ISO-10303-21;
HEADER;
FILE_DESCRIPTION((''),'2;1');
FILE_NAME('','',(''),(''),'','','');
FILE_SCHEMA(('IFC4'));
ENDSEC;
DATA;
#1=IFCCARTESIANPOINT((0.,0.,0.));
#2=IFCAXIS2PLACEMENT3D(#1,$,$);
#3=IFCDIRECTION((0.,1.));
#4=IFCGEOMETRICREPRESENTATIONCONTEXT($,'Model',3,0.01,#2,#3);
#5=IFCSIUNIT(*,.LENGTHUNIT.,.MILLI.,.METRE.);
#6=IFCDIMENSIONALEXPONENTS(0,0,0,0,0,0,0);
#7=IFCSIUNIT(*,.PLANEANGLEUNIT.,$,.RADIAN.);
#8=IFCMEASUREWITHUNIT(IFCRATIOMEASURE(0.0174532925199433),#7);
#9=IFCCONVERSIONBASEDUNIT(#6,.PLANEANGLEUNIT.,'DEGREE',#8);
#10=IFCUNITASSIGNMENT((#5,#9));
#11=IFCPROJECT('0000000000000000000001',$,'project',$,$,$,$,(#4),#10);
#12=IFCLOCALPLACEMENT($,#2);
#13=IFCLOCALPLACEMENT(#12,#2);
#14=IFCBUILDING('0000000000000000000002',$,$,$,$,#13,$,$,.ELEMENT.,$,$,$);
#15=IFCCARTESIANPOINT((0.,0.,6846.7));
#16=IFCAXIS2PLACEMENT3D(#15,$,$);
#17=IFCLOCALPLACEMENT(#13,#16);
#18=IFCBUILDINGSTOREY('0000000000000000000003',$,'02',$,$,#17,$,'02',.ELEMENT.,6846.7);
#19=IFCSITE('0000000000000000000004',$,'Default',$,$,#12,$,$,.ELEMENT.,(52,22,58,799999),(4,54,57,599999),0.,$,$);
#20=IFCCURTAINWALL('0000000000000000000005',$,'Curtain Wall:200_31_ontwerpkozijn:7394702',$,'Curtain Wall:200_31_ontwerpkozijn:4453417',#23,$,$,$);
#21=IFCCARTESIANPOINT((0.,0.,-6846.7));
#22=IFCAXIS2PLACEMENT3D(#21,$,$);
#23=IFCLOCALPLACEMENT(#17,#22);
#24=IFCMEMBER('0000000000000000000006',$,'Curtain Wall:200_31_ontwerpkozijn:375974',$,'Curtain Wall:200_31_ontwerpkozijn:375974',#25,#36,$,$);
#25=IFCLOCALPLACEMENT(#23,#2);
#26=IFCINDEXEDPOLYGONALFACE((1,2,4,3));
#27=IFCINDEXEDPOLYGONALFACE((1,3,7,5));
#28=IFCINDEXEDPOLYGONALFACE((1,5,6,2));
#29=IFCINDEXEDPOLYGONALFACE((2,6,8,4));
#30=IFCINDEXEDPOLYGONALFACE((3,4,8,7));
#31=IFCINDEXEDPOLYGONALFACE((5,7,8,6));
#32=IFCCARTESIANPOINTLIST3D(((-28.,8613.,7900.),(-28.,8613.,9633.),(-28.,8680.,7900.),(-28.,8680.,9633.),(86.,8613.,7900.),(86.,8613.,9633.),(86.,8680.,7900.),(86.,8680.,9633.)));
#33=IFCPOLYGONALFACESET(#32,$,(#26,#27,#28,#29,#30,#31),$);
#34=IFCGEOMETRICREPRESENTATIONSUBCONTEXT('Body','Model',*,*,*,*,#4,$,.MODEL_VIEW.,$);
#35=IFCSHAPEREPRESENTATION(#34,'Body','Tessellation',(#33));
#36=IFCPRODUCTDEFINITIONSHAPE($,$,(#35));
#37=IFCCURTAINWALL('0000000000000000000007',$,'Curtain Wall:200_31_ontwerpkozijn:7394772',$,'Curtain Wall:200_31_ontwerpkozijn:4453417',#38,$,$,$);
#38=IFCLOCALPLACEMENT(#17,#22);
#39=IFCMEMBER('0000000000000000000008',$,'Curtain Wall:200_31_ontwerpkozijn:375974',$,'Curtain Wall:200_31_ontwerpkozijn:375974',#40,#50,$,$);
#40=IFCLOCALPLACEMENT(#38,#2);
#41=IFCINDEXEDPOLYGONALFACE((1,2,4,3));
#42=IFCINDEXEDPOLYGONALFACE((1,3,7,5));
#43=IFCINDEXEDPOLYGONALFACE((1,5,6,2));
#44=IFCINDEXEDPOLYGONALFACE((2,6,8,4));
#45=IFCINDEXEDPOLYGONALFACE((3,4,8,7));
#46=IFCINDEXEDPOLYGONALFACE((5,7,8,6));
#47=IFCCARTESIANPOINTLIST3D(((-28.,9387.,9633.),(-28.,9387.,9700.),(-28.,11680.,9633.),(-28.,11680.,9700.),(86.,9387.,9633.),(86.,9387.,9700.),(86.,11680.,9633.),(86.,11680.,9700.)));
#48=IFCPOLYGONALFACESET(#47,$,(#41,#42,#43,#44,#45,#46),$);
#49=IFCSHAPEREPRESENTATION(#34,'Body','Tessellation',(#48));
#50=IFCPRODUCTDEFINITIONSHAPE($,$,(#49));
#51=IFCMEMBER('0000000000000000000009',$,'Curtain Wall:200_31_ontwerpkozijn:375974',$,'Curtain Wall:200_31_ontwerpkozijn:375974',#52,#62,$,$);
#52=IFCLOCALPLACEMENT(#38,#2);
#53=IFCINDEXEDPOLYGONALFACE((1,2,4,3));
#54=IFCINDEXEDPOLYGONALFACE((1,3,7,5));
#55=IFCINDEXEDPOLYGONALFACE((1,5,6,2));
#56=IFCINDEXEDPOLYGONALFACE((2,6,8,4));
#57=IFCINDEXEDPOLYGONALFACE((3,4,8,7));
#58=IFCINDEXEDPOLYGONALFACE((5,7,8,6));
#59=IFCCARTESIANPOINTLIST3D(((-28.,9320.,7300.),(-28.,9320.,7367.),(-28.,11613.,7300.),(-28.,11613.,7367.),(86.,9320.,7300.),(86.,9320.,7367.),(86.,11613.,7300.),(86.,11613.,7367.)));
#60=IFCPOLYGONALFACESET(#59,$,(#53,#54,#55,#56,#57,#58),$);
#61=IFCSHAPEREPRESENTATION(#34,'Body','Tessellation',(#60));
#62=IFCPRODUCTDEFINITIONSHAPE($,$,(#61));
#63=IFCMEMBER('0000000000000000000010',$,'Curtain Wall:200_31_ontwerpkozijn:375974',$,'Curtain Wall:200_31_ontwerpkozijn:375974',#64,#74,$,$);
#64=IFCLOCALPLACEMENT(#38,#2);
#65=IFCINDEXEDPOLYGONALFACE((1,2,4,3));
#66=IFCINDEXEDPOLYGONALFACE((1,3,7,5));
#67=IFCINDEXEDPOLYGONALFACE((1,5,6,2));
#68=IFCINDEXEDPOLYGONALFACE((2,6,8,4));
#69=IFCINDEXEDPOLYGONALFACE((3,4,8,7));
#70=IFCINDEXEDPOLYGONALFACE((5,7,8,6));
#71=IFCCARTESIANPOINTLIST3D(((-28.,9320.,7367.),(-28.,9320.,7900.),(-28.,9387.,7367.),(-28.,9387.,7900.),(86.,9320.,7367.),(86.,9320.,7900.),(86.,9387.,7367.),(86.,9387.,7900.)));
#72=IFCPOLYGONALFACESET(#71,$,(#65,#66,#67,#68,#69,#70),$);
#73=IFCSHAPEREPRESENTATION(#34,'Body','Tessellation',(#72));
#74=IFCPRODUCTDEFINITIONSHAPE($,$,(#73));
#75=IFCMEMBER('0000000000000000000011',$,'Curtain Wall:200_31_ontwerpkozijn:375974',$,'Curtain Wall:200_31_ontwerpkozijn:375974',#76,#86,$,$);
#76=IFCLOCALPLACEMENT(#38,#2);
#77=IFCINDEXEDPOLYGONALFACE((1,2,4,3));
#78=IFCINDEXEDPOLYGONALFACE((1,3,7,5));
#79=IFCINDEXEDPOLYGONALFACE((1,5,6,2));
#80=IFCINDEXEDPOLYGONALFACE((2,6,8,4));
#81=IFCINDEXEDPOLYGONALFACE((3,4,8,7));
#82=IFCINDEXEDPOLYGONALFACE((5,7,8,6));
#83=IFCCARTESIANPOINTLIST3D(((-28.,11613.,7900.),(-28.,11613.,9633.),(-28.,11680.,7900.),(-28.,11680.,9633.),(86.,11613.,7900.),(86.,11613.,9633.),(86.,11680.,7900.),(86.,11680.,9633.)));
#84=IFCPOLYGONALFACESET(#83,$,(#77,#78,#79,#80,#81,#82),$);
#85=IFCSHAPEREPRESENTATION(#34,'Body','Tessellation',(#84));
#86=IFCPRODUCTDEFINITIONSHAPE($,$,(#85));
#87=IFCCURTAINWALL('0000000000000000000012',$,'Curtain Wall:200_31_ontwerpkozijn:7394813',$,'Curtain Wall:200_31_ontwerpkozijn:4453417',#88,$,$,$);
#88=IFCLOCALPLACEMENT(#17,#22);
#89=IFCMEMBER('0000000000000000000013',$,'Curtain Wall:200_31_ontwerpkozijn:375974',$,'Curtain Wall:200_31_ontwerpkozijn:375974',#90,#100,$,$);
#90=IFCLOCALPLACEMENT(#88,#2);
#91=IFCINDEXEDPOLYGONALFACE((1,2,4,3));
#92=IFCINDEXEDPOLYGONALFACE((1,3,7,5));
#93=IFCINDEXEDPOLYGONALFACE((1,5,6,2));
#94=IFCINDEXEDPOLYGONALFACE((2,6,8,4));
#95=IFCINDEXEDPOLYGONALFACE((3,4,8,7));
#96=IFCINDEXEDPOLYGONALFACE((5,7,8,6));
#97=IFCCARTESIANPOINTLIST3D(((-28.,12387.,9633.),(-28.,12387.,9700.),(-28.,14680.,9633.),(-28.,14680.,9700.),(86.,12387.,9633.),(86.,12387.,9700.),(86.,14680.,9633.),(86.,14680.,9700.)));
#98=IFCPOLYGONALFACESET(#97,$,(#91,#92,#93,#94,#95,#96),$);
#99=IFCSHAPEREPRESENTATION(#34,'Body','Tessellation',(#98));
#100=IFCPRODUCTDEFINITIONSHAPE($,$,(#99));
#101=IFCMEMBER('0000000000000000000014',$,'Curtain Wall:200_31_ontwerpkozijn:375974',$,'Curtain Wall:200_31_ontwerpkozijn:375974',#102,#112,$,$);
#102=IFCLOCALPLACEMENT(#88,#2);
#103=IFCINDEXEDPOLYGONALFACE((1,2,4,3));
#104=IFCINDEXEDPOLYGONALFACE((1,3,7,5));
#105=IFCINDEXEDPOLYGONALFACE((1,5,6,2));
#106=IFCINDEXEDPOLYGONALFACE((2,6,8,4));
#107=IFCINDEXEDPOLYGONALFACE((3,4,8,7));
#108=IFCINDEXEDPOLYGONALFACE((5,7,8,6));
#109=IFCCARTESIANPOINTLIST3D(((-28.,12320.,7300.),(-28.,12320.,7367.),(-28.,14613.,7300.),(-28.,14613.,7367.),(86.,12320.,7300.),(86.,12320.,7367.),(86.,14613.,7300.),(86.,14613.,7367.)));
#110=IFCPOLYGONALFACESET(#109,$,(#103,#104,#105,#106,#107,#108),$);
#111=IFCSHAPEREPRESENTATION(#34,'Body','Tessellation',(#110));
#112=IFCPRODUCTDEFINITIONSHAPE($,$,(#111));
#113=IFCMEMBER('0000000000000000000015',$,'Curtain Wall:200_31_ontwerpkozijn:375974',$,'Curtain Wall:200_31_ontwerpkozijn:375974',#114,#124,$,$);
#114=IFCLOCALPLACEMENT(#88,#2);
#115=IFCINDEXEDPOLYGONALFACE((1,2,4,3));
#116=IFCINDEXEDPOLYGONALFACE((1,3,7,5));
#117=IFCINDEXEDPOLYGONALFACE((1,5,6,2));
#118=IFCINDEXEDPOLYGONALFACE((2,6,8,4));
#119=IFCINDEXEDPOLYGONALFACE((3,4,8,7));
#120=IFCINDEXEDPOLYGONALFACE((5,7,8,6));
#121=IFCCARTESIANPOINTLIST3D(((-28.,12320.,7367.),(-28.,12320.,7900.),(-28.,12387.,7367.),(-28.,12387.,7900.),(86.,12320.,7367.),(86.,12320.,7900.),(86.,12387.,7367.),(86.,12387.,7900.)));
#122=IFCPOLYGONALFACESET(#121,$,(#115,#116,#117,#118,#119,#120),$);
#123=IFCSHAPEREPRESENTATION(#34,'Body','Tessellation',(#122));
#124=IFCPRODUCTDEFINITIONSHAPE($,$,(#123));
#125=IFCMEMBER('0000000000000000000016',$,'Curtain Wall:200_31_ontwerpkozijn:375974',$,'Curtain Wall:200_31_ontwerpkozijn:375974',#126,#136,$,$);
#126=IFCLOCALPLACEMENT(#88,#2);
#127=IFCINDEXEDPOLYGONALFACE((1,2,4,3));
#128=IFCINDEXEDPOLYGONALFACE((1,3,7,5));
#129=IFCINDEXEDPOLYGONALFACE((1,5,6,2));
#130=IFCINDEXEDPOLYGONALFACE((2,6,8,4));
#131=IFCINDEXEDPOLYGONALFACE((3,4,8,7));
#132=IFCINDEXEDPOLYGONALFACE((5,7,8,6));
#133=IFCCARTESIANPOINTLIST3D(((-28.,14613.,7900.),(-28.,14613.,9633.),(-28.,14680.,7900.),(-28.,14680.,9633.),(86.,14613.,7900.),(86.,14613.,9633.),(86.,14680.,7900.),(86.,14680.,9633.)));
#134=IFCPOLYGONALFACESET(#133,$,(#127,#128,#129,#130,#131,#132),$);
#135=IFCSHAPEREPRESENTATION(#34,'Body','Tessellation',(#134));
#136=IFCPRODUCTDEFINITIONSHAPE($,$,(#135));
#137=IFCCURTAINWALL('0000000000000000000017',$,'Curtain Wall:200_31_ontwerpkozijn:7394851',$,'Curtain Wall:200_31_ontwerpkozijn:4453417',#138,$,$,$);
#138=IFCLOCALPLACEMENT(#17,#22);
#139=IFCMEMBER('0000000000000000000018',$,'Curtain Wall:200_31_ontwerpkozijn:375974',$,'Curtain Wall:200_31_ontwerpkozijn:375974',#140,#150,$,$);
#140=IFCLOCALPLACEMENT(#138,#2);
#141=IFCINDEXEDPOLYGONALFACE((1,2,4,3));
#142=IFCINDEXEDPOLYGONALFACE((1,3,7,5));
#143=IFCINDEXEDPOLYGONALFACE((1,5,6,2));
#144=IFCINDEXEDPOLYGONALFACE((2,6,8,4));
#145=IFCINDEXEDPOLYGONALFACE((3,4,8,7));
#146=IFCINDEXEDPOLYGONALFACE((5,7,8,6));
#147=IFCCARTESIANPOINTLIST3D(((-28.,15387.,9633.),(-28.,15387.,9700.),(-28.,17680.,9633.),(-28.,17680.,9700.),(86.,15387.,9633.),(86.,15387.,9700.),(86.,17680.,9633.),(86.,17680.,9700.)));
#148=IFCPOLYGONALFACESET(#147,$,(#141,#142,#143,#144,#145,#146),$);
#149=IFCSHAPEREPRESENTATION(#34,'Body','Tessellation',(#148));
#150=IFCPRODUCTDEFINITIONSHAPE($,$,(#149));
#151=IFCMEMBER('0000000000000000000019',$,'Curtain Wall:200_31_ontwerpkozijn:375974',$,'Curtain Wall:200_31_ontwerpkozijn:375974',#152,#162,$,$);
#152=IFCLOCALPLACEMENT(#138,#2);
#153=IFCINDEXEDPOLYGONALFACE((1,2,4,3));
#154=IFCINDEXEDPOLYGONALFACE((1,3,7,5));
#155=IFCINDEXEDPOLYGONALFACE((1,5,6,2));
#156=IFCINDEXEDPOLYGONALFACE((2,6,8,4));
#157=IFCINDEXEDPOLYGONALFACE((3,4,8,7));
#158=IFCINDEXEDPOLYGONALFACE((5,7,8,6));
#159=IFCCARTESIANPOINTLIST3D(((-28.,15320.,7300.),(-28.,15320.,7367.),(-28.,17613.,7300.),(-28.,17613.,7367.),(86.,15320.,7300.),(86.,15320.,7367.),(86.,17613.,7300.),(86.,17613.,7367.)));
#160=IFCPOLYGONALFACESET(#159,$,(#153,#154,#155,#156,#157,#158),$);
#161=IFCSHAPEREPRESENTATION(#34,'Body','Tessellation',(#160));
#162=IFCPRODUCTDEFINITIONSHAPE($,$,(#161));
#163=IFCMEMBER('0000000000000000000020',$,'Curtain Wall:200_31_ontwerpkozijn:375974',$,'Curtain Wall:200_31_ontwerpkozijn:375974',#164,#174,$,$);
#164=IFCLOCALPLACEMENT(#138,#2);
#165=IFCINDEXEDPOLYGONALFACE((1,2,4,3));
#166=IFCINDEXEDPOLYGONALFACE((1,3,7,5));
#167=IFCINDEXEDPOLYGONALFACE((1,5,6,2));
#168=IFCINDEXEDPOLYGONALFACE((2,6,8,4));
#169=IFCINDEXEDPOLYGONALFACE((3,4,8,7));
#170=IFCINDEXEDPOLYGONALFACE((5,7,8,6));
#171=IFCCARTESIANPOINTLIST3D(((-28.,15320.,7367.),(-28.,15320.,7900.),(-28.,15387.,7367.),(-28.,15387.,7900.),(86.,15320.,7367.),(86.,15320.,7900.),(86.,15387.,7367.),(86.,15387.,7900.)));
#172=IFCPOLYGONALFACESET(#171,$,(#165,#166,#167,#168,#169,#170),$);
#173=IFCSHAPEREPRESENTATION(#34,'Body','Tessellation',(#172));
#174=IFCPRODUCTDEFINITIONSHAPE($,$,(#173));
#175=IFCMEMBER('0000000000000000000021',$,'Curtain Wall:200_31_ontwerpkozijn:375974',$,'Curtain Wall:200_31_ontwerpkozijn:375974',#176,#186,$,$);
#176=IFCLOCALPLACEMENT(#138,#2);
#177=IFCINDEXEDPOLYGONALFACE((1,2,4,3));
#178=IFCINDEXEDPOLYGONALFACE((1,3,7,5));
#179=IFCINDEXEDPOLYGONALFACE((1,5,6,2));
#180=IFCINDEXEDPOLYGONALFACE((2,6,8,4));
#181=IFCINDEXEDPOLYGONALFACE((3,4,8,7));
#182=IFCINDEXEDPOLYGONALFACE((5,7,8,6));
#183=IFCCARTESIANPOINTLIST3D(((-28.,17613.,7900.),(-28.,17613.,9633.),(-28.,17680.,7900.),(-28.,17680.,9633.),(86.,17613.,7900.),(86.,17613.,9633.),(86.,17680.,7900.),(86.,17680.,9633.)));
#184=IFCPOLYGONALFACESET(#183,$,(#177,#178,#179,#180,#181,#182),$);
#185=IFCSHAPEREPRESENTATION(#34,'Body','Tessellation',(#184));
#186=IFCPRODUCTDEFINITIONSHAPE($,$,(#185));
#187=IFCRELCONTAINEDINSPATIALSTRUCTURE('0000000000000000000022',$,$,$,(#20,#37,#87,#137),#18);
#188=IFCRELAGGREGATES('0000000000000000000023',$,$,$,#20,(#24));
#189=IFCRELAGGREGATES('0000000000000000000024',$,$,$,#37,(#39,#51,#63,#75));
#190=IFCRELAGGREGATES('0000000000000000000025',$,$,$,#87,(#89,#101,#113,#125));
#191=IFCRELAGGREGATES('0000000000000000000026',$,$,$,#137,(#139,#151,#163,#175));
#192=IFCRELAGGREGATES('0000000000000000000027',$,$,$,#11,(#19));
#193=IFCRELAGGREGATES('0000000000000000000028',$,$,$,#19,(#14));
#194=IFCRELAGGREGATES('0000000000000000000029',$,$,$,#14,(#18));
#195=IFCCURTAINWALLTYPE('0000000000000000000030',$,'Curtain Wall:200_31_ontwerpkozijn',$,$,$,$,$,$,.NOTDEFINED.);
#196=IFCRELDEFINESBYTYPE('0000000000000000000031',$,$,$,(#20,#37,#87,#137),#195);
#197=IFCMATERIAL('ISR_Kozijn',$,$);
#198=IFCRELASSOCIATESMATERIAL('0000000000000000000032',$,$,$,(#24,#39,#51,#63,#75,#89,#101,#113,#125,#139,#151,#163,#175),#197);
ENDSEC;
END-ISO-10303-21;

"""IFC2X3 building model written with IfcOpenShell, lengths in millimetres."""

from ifc_helpers import new_model, entity, si_unit, converted_unit, direction, frame, frame_2d, origin, origin_2d_with_axis, place, context, subcontext, project, spatial, rectangle, extrude, material, type_object, element, aggregate, save


model = new_model("IFC2X3")

# Units and contexts
model_context = context("Model", 3, precision=0.01, world=origin(), true_north=direction((0.0, 1.0)))
body_context = subcontext(model_context, "Body", "Model", "MODEL_VIEW")
ifc_project = project(units=[si_unit("LENGTHUNIT", "METRE", prefix="MILLI"), converted_unit("PLANEANGLEUNIT", "DEGREE", entity("IfcRatioMeasure", 0.0174532925199433), si_unit("PLANEANGLEUNIT", "RADIAN"), dimensions=[0, 0, 0, 0, 0, 0, 0])], contexts=[model_context])

# Site, building, storey
site_placement = place(None, origin())
site = spatial("IfcSite", under=ifc_project, at=site_placement, Name="Default", CompositionType="ELEMENT", RefLatitude=(52, 22, 58, 799999), RefLongitude=(4, 54, 57, 599999), RefElevation=0.0)
building_placement = place(site_placement, origin())
building = spatial("IfcBuilding", under=site, at=building_placement, CompositionType="ELEMENT")
storey_placement = place(building_placement, frame((0.0, 0.0, 6846.7)))
storey = spatial("IfcBuildingStorey", under=building, at=storey_placement, Name="02", LongName="02", CompositionType="ELEMENT", Elevation=6846.7)

# Curtain wall, member
curtain_wall_type = type_object("IfcCurtainWallType", Name="Curtain Wall:200_31_ontwerpkozijn", PredefinedType="NOTDEFINED")
curtain_wall_1_placement = place(storey_placement, frame((0.0, 0.0, -6846.7)))
curtain_wall_1 = element("IfcCurtainWall", 1, at=curtain_wall_1_placement, inside=storey, type_object=curtain_wall_type, Name="Curtain Wall:200_31_ontwerpkozijn:7394702", ObjectType="Curtain Wall:200_31_ontwerpkozijn:4453417")
ifc_material = material(Name="ISR_Kozijn")
member_1_placement = place(curtain_wall_1_placement, origin())
member_1 = element("IfcMember", 2, at=member_1_placement, material=ifc_material, Name="Curtain Wall:200_31_ontwerpkozijn:375974", ObjectType="Curtain Wall:200_31_ontwerpkozijn:375974", context=body_context, shape_type="SweptSolid", body=[
    extrude(rectangle(XDim=114.0, YDim=67.0, at=origin_2d_with_axis()), frame((29.0, 8646.5, 9633.0), z_axis=(0.0, 0.0, -1.0), x_axis=(-1.0, 0.0, 0.0)), (0.0, 0.0, 1.0), 1733.0),
])
aggregate(curtain_wall_1, [member_1])

# Curtain walls, members
curtain_wall_2_placement = place(storey_placement, frame((0.0, 0.0, -6846.7)))
curtain_wall_2 = element("IfcCurtainWall", 3, at=curtain_wall_2_placement, inside=storey, type_object=curtain_wall_type, Name="Curtain Wall:200_31_ontwerpkozijn:7394772", ObjectType="Curtain Wall:200_31_ontwerpkozijn:4453417")
member_2_placement = place(curtain_wall_2_placement, origin())
member_2 = element("IfcMember", 4, at=member_2_placement, material=ifc_material, Name="Curtain Wall:200_31_ontwerpkozijn:375974", ObjectType="Curtain Wall:200_31_ontwerpkozijn:375974", context=body_context, shape_type="SweptSolid", body=[
    extrude(rectangle(XDim=67.0, YDim=114.0, at=origin_2d_with_axis()), frame((29.0, 9387.0, 9666.5), z_axis=(0.0, 1.0, 0.0), x_axis=(0.0, 0.0, -1.0)), (0.0, 0.0, 1.0), 2293.0),
])
member_3_placement = place(curtain_wall_2_placement, origin())
member_3 = element("IfcMember", 5, at=member_3_placement, material=ifc_material, Name="Curtain Wall:200_31_ontwerpkozijn:375974", ObjectType="Curtain Wall:200_31_ontwerpkozijn:375974", context=body_context, shape_type="SweptSolid", body=[
    extrude(rectangle(XDim=67.0, YDim=114.0, at=frame_2d((0.0, 0.0), x_axis=(1.0, 0.0))), frame((29.0, 11613.0, 7333.5), z_axis=(0.0, -1.0, 0.0), x_axis=(0.0, 0.0, -1.0)), (0.0, 0.0, 1.0), 2293.0),
])
member_4_placement = place(curtain_wall_2_placement, origin())
member_4 = element("IfcMember", 6, at=member_4_placement, material=ifc_material, Name="Curtain Wall:200_31_ontwerpkozijn:375974", ObjectType="Curtain Wall:200_31_ontwerpkozijn:375974", context=body_context, shape_type="SweptSolid", body=[
    extrude(rectangle(XDim=114.0, YDim=67.0, at=origin_2d_with_axis()), frame((29.0, 9353.5, 7367.0), z_axis=(0.0, 0.0, 1.0), x_axis=(-1.0, 0.0, 0.0)), (0.0, 0.0, 1.0), 533.0),
])
member_5_placement = place(curtain_wall_2_placement, origin())
member_5 = element("IfcMember", 7, at=member_5_placement, material=ifc_material, Name="Curtain Wall:200_31_ontwerpkozijn:375974", ObjectType="Curtain Wall:200_31_ontwerpkozijn:375974", context=body_context, shape_type="SweptSolid", body=[
    extrude(rectangle(XDim=114.0, YDim=67.0, at=frame_2d((0.0, 0.0), x_axis=(1.0, 0.0))), frame((29.0, 11646.5, 9633.0), z_axis=(0.0, 0.0, -1.0), x_axis=(-1.0, 0.0, 0.0)), (0.0, 0.0, 1.0), 1733.0),
])
aggregate(curtain_wall_2, [member_2, member_3, member_4, member_5])
curtain_wall_3_placement = place(storey_placement, frame((0.0, 0.0, -6846.7)))
curtain_wall_3 = element("IfcCurtainWall", 8, at=curtain_wall_3_placement, inside=storey, type_object=curtain_wall_type, Name="Curtain Wall:200_31_ontwerpkozijn:7394813", ObjectType="Curtain Wall:200_31_ontwerpkozijn:4453417")
member_6_placement = place(curtain_wall_3_placement, origin())
member_6 = element("IfcMember", 9, at=member_6_placement, material=ifc_material, Name="Curtain Wall:200_31_ontwerpkozijn:375974", ObjectType="Curtain Wall:200_31_ontwerpkozijn:375974", context=body_context, shape_type="SweptSolid", body=[
    extrude(rectangle(XDim=67.0, YDim=114.0, at=origin_2d_with_axis()), frame((29.0, 12387.0, 9666.5), z_axis=(0.0, 1.0, 0.0), x_axis=(0.0, 0.0, -1.0)), (0.0, 0.0, 1.0), 2293.0),
])
member_7_placement = place(curtain_wall_3_placement, origin())
member_7 = element("IfcMember", 10, at=member_7_placement, material=ifc_material, Name="Curtain Wall:200_31_ontwerpkozijn:375974", ObjectType="Curtain Wall:200_31_ontwerpkozijn:375974", context=body_context, shape_type="SweptSolid", body=[
    extrude(rectangle(XDim=67.0, YDim=114.0, at=frame_2d((0.0, 0.0), x_axis=(1.0, 0.0))), frame((29.0, 14613.0, 7333.5), z_axis=(0.0, -1.0, 0.0), x_axis=(0.0, 0.0, -1.0)), (0.0, 0.0, 1.0), 2293.0),
])
member_8_placement = place(curtain_wall_3_placement, origin())
member_8 = element("IfcMember", 11, at=member_8_placement, material=ifc_material, Name="Curtain Wall:200_31_ontwerpkozijn:375974", ObjectType="Curtain Wall:200_31_ontwerpkozijn:375974", context=body_context, shape_type="SweptSolid", body=[
    extrude(rectangle(XDim=114.0, YDim=67.0, at=frame_2d((0.0, 0.0), x_axis=(1.0, 0.0))), frame((29.0, 12353.5, 7367.0), z_axis=(0.0, 0.0, 1.0), x_axis=(-1.0, 0.0, 0.0)), (0.0, 0.0, 1.0), 533.0),
])
member_9_placement = place(curtain_wall_3_placement, origin())
member_9 = element("IfcMember", 12, at=member_9_placement, material=ifc_material, Name="Curtain Wall:200_31_ontwerpkozijn:375974", ObjectType="Curtain Wall:200_31_ontwerpkozijn:375974", context=body_context, shape_type="SweptSolid", body=[
    extrude(rectangle(XDim=114.0, YDim=67.0, at=frame_2d((0.0, 0.0), x_axis=(1.0, 0.0))), frame((29.0, 14646.5, 9633.0), z_axis=(0.0, 0.0, -1.0), x_axis=(-1.0, 0.0, 0.0)), (0.0, 0.0, 1.0), 1733.0),
])
aggregate(curtain_wall_3, [member_6, member_7, member_8, member_9])
curtain_wall_4_placement = place(storey_placement, frame((0.0, 0.0, -6846.7)))
curtain_wall_4 = element("IfcCurtainWall", 13, at=curtain_wall_4_placement, inside=storey, type_object=curtain_wall_type, Name="Curtain Wall:200_31_ontwerpkozijn:7394851", ObjectType="Curtain Wall:200_31_ontwerpkozijn:4453417")
member_10_placement = place(curtain_wall_4_placement, origin())
member_10 = element("IfcMember", 14, at=member_10_placement, material=ifc_material, Name="Curtain Wall:200_31_ontwerpkozijn:375974", ObjectType="Curtain Wall:200_31_ontwerpkozijn:375974", context=body_context, shape_type="SweptSolid", body=[
    extrude(rectangle(XDim=67.0, YDim=114.0, at=origin_2d_with_axis()), frame((29.0, 15387.0, 9666.5), z_axis=(0.0, 1.0, 0.0), x_axis=(0.0, 0.0, -1.0)), (0.0, 0.0, 1.0), 2293.0),
])
member_11_placement = place(curtain_wall_4_placement, origin())
member_11 = element("IfcMember", 15, at=member_11_placement, material=ifc_material, Name="Curtain Wall:200_31_ontwerpkozijn:375974", ObjectType="Curtain Wall:200_31_ontwerpkozijn:375974", context=body_context, shape_type="SweptSolid", body=[
    extrude(rectangle(XDim=67.0, YDim=114.0, at=frame_2d((0.0, 0.0), x_axis=(1.0, 0.0))), frame((29.0, 17613.0, 7333.5), z_axis=(0.0, -1.0, 0.0), x_axis=(0.0, 0.0, -1.0)), (0.0, 0.0, 1.0), 2293.0),
])
member_12_placement = place(curtain_wall_4_placement, origin())
member_12 = element("IfcMember", 16, at=member_12_placement, material=ifc_material, Name="Curtain Wall:200_31_ontwerpkozijn:375974", ObjectType="Curtain Wall:200_31_ontwerpkozijn:375974", context=body_context, shape_type="SweptSolid", body=[
    extrude(rectangle(XDim=114.0, YDim=67.0, at=frame_2d((0.0, 0.0), x_axis=(1.0, 0.0))), frame((29.0, 15353.5, 7367.0), z_axis=(0.0, 0.0, 1.0), x_axis=(-1.0, 0.0, 0.0)), (0.0, 0.0, 1.0), 533.0),
])
member_13_placement = place(curtain_wall_4_placement, origin())
member_13 = element("IfcMember", 17, at=member_13_placement, material=ifc_material, Name="Curtain Wall:200_31_ontwerpkozijn:375974", ObjectType="Curtain Wall:200_31_ontwerpkozijn:375974", context=body_context, shape_type="SweptSolid", body=[
    extrude(rectangle(XDim=114.0, YDim=67.0, at=frame_2d((0.0, 0.0), x_axis=(1.0, 0.0))), frame((29.0, 17646.5, 9633.0), z_axis=(0.0, 0.0, -1.0), x_axis=(-1.0, 0.0, 0.0)), (0.0, 0.0, 1.0), 1733.0),
])
aggregate(curtain_wall_4, [member_10, member_11, member_12, member_13])

save(model, "model.ifc")
